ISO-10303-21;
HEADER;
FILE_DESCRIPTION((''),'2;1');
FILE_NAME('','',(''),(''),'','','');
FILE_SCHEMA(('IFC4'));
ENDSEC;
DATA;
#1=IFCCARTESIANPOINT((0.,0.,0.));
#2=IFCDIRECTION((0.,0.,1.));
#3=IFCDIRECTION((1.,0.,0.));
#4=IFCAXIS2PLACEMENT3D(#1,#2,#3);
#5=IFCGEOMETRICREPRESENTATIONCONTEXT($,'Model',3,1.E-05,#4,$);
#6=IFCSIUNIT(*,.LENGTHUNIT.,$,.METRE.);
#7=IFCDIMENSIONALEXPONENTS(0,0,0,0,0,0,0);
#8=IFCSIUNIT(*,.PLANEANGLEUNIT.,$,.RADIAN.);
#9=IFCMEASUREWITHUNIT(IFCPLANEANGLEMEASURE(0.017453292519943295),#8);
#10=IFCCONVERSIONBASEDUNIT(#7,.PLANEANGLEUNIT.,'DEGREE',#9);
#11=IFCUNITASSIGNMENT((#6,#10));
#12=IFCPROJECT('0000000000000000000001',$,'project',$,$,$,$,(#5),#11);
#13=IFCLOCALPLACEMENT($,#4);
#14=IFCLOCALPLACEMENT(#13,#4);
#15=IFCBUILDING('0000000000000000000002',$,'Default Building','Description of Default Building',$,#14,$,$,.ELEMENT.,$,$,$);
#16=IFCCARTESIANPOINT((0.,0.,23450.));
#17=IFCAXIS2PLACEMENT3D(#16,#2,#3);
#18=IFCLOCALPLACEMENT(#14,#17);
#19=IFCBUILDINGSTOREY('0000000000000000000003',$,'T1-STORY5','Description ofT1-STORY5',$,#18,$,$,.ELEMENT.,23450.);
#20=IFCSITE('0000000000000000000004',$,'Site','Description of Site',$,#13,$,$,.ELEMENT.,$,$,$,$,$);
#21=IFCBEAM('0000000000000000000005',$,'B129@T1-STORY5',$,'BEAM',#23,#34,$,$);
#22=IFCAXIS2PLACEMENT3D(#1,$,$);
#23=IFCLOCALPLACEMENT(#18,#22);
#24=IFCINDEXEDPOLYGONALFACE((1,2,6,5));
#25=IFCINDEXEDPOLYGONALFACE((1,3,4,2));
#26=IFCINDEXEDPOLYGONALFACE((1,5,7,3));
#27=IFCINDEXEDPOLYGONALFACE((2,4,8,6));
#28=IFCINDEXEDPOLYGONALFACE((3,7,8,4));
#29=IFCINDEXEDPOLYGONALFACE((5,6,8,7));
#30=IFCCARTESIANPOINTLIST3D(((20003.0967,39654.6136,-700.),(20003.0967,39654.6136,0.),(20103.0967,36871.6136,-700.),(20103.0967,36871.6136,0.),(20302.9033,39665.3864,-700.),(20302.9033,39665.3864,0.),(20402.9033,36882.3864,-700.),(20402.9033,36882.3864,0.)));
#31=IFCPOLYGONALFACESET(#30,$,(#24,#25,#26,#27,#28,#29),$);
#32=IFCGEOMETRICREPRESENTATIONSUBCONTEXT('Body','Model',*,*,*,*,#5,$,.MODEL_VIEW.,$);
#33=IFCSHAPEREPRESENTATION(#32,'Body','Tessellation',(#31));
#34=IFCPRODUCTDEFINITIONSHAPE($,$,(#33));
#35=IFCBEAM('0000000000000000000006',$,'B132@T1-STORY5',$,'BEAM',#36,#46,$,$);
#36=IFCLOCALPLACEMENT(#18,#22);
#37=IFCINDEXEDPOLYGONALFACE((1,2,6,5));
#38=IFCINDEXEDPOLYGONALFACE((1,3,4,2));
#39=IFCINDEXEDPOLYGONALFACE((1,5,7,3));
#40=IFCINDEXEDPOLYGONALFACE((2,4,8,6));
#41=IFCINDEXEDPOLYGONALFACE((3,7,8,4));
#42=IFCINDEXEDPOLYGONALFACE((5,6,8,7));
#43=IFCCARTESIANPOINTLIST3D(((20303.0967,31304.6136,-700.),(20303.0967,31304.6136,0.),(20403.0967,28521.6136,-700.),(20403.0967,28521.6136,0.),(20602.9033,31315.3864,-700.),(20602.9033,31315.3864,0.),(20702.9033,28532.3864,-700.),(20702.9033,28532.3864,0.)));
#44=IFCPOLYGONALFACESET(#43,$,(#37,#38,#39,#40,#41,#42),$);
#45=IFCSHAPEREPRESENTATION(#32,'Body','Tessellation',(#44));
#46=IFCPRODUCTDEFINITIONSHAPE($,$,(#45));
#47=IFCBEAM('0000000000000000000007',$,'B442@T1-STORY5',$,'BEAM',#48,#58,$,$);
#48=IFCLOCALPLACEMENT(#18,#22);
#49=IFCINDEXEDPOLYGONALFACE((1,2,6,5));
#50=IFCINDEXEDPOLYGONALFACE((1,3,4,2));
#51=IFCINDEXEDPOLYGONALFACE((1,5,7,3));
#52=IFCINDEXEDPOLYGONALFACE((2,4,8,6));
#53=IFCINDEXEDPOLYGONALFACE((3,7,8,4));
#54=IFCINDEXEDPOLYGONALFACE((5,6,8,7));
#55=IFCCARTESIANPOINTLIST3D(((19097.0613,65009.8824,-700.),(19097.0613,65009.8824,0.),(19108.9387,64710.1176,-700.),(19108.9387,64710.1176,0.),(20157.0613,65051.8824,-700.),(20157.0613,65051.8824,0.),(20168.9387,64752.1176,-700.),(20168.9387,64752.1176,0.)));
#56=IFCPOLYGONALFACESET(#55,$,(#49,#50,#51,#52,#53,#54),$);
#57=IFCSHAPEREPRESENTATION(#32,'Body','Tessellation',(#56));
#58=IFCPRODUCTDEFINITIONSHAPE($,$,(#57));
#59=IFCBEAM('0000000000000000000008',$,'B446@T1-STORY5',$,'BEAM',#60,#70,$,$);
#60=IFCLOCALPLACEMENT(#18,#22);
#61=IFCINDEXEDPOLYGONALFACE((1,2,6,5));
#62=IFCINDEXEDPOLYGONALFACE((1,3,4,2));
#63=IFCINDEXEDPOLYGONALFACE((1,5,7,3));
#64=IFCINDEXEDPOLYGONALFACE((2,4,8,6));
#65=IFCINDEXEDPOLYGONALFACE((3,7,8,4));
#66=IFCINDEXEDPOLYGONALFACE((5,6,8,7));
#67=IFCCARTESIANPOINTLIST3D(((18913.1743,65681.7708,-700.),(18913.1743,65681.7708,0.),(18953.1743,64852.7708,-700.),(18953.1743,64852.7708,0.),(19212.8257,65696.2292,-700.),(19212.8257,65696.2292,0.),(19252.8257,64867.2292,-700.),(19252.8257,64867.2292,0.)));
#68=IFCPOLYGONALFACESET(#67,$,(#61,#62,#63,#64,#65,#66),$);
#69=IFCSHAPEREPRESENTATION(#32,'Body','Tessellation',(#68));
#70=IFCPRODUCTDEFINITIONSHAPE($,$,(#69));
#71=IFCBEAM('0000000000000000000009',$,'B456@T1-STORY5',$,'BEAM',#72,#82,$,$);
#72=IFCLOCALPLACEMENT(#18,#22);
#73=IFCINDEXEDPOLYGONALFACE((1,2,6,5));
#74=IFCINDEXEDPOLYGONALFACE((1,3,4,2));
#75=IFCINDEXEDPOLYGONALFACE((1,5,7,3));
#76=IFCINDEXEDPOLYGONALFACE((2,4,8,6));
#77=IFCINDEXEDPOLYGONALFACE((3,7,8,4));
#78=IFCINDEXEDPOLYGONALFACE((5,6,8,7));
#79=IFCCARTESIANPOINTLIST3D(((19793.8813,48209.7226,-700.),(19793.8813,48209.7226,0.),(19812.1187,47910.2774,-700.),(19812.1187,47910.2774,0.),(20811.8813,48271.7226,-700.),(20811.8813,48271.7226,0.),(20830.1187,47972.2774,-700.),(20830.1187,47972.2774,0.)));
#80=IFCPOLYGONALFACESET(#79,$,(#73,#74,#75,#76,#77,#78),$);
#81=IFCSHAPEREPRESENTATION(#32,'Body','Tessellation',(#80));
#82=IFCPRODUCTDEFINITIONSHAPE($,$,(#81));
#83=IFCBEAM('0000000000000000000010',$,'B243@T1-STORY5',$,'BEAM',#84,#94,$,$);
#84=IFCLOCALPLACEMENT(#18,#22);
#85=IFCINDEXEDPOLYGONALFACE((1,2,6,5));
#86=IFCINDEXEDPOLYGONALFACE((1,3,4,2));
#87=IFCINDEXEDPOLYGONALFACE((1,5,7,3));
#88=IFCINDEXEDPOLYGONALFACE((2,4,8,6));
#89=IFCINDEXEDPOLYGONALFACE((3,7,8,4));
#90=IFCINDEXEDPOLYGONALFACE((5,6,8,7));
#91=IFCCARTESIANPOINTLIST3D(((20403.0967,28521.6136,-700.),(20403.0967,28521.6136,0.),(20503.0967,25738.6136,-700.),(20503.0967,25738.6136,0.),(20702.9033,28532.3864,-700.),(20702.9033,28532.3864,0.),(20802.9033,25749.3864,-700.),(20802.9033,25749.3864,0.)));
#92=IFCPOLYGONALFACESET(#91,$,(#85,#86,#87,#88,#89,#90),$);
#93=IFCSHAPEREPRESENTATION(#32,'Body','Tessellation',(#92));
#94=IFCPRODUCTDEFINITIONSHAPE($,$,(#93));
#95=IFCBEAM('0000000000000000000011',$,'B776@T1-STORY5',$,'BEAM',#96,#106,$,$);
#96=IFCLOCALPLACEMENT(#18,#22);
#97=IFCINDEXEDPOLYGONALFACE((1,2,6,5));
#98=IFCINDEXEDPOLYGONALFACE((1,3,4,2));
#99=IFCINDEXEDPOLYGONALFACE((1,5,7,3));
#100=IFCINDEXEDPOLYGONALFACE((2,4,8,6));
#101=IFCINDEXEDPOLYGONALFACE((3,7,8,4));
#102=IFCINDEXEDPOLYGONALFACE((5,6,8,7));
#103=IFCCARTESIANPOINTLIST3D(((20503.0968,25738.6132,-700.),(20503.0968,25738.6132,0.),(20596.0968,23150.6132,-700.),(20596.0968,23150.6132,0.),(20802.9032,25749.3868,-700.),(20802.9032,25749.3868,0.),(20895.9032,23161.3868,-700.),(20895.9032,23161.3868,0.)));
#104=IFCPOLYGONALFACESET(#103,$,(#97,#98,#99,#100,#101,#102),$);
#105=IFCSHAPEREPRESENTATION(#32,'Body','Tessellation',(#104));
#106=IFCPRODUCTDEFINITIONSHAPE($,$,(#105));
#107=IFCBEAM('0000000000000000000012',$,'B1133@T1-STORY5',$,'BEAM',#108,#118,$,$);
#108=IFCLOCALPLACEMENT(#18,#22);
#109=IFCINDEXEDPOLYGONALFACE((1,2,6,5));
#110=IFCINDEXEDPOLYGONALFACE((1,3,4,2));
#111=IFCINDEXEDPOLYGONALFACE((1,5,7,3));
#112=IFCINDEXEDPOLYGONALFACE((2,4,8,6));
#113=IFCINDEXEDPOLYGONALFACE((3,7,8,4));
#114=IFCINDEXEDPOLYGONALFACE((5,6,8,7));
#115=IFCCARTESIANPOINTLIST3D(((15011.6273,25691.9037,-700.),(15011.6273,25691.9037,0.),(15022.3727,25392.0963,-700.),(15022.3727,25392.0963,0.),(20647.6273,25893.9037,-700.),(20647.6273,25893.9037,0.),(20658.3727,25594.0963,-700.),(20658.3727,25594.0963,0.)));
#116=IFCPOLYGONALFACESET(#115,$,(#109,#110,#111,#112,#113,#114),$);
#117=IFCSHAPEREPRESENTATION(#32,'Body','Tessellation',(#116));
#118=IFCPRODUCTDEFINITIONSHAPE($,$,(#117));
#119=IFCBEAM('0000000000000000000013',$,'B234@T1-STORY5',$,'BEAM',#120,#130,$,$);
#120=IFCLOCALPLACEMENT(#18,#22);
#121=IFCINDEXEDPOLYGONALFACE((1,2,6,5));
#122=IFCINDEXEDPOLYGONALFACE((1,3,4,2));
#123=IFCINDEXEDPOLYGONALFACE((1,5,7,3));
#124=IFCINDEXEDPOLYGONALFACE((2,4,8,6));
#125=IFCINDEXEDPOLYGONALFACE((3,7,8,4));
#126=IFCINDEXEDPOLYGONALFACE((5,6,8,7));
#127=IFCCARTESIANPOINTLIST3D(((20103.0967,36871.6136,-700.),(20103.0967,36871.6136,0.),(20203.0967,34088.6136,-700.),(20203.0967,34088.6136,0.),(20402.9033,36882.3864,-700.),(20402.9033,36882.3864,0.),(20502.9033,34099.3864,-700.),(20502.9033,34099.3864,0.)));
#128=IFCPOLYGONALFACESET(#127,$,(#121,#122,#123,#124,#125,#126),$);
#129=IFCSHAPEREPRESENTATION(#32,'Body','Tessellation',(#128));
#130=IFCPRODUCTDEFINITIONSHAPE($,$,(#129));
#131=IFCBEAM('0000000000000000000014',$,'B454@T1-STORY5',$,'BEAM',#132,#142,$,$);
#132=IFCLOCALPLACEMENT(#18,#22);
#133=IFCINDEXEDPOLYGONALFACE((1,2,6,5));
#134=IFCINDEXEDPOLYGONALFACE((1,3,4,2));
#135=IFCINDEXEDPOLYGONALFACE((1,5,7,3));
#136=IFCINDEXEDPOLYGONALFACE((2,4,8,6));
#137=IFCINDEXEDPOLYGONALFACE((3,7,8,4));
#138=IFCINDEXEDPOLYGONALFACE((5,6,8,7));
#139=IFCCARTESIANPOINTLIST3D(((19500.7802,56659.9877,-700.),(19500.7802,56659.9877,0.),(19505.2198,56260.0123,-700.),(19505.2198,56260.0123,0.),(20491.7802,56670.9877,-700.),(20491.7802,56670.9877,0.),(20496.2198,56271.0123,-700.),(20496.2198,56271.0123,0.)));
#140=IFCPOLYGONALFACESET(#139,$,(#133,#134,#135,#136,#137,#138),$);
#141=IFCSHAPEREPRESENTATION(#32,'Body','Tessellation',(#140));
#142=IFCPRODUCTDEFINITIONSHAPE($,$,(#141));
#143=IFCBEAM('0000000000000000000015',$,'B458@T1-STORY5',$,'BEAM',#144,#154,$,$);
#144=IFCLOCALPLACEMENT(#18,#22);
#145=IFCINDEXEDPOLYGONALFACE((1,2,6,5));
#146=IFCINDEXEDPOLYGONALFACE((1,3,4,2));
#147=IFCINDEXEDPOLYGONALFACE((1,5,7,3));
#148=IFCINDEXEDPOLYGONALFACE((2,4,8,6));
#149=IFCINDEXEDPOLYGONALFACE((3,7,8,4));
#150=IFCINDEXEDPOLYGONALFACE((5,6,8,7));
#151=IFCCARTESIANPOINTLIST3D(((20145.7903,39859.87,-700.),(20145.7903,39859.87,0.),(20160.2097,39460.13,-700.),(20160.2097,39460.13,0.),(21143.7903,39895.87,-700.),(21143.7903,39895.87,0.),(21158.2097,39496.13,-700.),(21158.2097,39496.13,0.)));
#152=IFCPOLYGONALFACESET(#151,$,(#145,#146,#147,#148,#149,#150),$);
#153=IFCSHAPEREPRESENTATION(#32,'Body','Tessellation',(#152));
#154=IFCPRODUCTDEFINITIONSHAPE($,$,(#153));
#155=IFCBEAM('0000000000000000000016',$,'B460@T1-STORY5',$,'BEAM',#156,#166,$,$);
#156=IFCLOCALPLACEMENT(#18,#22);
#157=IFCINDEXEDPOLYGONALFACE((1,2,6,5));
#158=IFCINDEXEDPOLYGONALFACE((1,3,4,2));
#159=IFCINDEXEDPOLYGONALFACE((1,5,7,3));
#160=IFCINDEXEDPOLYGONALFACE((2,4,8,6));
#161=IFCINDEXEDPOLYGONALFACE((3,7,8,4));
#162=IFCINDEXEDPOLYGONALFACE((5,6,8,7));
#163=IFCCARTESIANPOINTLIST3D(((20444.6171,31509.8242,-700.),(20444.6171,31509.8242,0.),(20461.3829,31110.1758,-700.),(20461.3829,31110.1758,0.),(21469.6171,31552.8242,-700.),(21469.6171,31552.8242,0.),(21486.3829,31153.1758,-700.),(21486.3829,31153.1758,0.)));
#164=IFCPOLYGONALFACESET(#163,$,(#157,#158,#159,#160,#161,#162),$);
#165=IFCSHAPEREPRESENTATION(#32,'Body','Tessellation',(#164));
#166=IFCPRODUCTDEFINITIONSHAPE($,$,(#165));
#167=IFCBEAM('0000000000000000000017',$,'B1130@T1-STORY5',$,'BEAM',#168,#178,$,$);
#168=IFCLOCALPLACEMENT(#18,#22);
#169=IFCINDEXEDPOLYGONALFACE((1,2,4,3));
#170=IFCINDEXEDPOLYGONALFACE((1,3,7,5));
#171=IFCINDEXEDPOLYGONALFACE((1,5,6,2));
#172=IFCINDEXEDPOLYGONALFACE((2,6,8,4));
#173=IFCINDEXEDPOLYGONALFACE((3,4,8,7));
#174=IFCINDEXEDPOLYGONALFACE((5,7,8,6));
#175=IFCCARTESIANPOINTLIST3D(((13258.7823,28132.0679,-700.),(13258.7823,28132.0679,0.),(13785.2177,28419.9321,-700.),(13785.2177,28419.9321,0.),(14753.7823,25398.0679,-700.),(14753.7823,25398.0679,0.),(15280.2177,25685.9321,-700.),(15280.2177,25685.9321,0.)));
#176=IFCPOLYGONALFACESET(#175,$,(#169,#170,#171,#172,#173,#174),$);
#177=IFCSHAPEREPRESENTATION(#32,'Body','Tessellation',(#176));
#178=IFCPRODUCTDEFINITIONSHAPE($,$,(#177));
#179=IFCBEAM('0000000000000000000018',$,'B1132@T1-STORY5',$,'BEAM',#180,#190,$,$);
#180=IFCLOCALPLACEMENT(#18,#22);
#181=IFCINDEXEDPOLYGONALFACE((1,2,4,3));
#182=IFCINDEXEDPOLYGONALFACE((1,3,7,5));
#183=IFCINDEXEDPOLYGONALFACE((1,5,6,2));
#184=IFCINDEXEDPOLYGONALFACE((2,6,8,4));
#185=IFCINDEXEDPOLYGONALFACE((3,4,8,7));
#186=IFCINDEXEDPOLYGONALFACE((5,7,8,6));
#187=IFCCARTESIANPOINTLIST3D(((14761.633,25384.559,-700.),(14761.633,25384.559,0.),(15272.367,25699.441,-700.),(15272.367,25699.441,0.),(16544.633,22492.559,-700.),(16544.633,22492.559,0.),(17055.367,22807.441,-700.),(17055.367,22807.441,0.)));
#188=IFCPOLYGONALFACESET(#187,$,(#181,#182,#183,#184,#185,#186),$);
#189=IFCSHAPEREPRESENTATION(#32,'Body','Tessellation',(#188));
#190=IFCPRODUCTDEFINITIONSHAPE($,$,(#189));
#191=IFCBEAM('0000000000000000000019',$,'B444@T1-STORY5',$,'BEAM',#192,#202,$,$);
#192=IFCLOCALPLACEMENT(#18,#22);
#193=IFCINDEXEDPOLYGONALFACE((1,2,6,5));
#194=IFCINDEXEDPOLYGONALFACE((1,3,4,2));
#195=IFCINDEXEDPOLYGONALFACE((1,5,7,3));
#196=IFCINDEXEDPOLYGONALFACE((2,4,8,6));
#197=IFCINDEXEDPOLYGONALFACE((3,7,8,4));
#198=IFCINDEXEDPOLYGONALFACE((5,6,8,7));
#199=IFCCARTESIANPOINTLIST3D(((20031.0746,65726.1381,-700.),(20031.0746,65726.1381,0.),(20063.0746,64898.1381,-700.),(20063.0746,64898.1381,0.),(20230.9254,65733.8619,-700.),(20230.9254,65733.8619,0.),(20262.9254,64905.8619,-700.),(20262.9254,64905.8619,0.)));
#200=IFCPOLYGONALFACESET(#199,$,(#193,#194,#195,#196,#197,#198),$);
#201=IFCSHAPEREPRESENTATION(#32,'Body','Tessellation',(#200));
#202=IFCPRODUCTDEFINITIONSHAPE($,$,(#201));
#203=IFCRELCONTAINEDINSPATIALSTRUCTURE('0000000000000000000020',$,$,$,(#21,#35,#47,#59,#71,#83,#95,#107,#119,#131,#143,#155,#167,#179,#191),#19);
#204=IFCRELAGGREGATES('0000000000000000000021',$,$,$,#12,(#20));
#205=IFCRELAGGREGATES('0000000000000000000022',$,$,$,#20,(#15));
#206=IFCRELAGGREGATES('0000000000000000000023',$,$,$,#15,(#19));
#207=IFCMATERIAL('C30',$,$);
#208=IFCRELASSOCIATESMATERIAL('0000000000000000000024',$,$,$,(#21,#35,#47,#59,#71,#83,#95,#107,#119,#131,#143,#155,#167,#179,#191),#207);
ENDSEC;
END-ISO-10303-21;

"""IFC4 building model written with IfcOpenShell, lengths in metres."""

from ifc_helpers import new_model, entity, si_unit, converted_unit, frame, origin_with_axes, place, context, subcontext, project, spatial, rectangle, extrude, material, element, save


model = new_model("IFC4")

# Units and contexts
model_context = context("Model", 3, precision=1e-05, world=origin_with_axes())
body_context = subcontext(model_context, "Body", "Model", "MODEL_VIEW")
ifc_project = project(units=[si_unit("LENGTHUNIT", "METRE"), converted_unit("PLANEANGLEUNIT", "DEGREE", entity("IfcPlaneAngleMeasure", 0.017453292519943295), si_unit("PLANEANGLEUNIT", "RADIAN"), dimensions=[0, 0, 0, 0, 0, 0, 0])], contexts=[model_context])

# Site, building, storey
site_placement = place(None, origin_with_axes())
site = spatial("IfcSite", under=ifc_project, at=site_placement, Name="Site", Description="Description of Site", CompositionType="ELEMENT")
building_placement = place(site_placement, origin_with_axes())
building = spatial("IfcBuilding", under=site, at=building_placement, Name="Default Building", Description="Description of Default Building", CompositionType="ELEMENT")
storey_placement = place(building_placement, frame((0.0, 0.0, 23450.0), z_axis=(0.0, 0.0, 1.0), x_axis=(1.0, 0.0, 0.0)))
storey = spatial("IfcBuildingStorey", under=building, at=storey_placement, Name="T1-STORY5", Description="Description ofT1-STORY5", CompositionType="ELEMENT", Elevation=23450.0)

# Beams
ifc_material_1 = material(Name="C30")
for number, where, z_axis, x_axis, name in (
    (1, (20153.0, 39660.0, -350.0), (0.035909, -0.999355, 0.0), (0.999355, 0.035909, 0.0), "B129@T1-STORY5"),
    (2, (20453.0, 31310.0, -350.0), (0.035909, -0.999355, 0.0), (0.999355, 0.035909, 0.0), "B132@T1-STORY5"),
):
    element("IfcBeam", number, at=place(storey_placement, frame(where, z_axis=z_axis, x_axis=x_axis)), inside=storey, material=ifc_material_1, Name=name, ObjectType="BEAM", context=body_context, shape_type="SweptSolid", body=[
        extrude(rectangle(XDim=300.0, YDim=700.0), origin_with_axes(), (0.0, 0.0, 1.0), 2784.796),
    ])
beam_1_placement = place(storey_placement, frame((19103.0, 64860.0, -350.0), z_axis=(0.999216, 0.039592, 0.0), x_axis=(-0.039592, 0.999216, 0.0)))
element("IfcBeam", 3, at=beam_1_placement, inside=storey, material=ifc_material_1, Name="B442@T1-STORY5", ObjectType="BEAM", context=body_context, shape_type="SweptSolid", body=[
    extrude(rectangle(XDim=300.0, YDim=700.0), origin_with_axes(), (0.0, 0.0, 1.0), 1060.8317),
])
beam_2_placement = place(storey_placement, frame((19063.0, 65689.0, -350.0), z_axis=(0.048195, -0.998838, 0.0), x_axis=(0.998838, 0.048195, 0.0)))
element("IfcBeam", 4, at=beam_2_placement, inside=storey, material=ifc_material_1, Name="B446@T1-STORY5", ObjectType="BEAM", context=body_context, shape_type="SweptSolid", body=[
    extrude(rectangle(XDim=300.0, YDim=700.0), origin_with_axes(), (0.0, 0.0, 1.0), 829.9645),
])
beam_3_placement = place(storey_placement, frame((19803.0, 48060.0, -350.0), z_axis=(0.998151, 0.060791, 0.0), x_axis=(-0.060791, 0.998151, 0.0)))
element("IfcBeam", 5, at=beam_3_placement, inside=storey, material=ifc_material_1, Name="B456@T1-STORY5", ObjectType="BEAM", context=body_context, shape_type="SweptSolid", body=[
    extrude(rectangle(XDim=300.0, YDim=700.0), origin_with_axes(), (0.0, 0.0, 1.0), 1019.8863),
])
beam_4_placement = place(storey_placement, frame((20553.0, 28527.0, -350.0), z_axis=(0.035909, -0.999355, 0.0), x_axis=(0.999355, 0.035909, 0.0)))
element("IfcBeam", 6, at=beam_4_placement, inside=storey, material=ifc_material_1, Name="B243@T1-STORY5", ObjectType="BEAM", context=body_context, shape_type="SweptSolid", body=[
    extrude(rectangle(XDim=300.0, YDim=700.0), origin_with_axes(), (0.0, 0.0, 1.0), 2784.796),
])
beam_5_placement = place(storey_placement, frame((20653.0, 25744.0, -350.0), z_axis=(0.035912, -0.999355, 0.0), x_axis=(0.999355, 0.035912, 0.0)))
element("IfcBeam", 7, at=beam_5_placement, inside=storey, material=ifc_material_1, Name="B776@T1-STORY5", ObjectType="BEAM", context=body_context, shape_type="SweptSolid", body=[
    extrude(rectangle(XDim=300.0, YDim=700.0), origin_with_axes(), (0.0, 0.0, 1.0), 2589.6704),
])
beam_6_placement = place(storey_placement, frame((15017.0, 25542.0, -350.0), z_axis=(0.999358, 0.035818, 0.0), x_axis=(-0.035818, 0.999358, 0.0)))
element("IfcBeam", 8, at=beam_6_placement, inside=storey, material=ifc_material_1, Name="B1133@T1-STORY5", ObjectType="BEAM", context=body_context, shape_type="SweptSolid", body=[
    extrude(rectangle(XDim=300.0, YDim=700.0), origin_with_axes(), (0.0, 0.0, 1.0), 5639.6188),
])
beam_7_placement = place(storey_placement, frame((20253.0, 36877.0, -350.0), z_axis=(0.035909, -0.999355, 0.0), x_axis=(0.999355, 0.035909, 0.0)))
element("IfcBeam", 9, at=beam_7_placement, inside=storey, material=ifc_material_1, Name="B234@T1-STORY5", ObjectType="BEAM", context=body_context, shape_type="SweptSolid", body=[
    extrude(rectangle(XDim=300.0, YDim=700.0), origin_with_axes(), (0.0, 0.0, 1.0), 2784.796),
])
beam_8_placement = place(storey_placement, frame((19503.0, 56460.0, -350.0), z_axis=(0.999938, 0.011099, 0.0), x_axis=(-0.011099, 0.999938, 0.0)))
element("IfcBeam", 10, at=beam_8_placement, inside=storey, material=ifc_material_1, Name="B454@T1-STORY5", ObjectType="BEAM", context=body_context, shape_type="SweptSolid", body=[
    extrude(rectangle(XDim=400.0, YDim=700.0), origin_with_axes(), (0.0, 0.0, 1.0), 991.061),
])
beam_9_placement = place(storey_placement, frame((20153.0, 39660.0, -350.0), z_axis=(0.99935, 0.036049, 0.0), x_axis=(-0.036049, 0.99935, 0.0)))
element("IfcBeam", 11, at=beam_9_placement, inside=storey, material=ifc_material_1, Name="B458@T1-STORY5", ObjectType="BEAM", context=body_context, shape_type="SweptSolid", body=[
    extrude(rectangle(XDim=400.0, YDim=700.0), origin_with_axes(), (0.0, 0.0, 1.0), 998.6491),
])
beam_10_placement = place(storey_placement, frame((20453.0, 31310.0, -350.0), z_axis=(0.999121, 0.041914, 0.0), x_axis=(-0.041914, 0.999121, 0.0)))
element("IfcBeam", 12, at=beam_10_placement, inside=storey, material=ifc_material_1, Name="B460@T1-STORY5", ObjectType="BEAM", context=body_context, shape_type="SweptSolid", body=[
    extrude(rectangle(XDim=400.0, YDim=700.0), origin_with_axes(), (0.0, 0.0, 1.0), 1025.9016),
])
beam_11_placement = place(storey_placement, frame((13522.0, 28276.0, -350.0), z_axis=(0.479774, -0.877392, 0.0), x_axis=(0.877392, 0.479774, 0.0)))
element("IfcBeam", 13, at=beam_11_placement, inside=storey, material=ifc_material_1, Name="B1130@T1-STORY5", ObjectType="BEAM", context=body_context, shape_type="SweptSolid", body=[
    extrude(rectangle(XDim=600.0, YDim=700.0), origin_with_axes(), (0.0, 0.0, 1.0), 3116.0521),
])
beam_12_placement = place(storey_placement, frame((15017.0, 25542.0, -350.0), z_axis=(0.524803, -0.851223, 0.0), x_axis=(0.851223, 0.524803, 0.0)))
element("IfcBeam", 14, at=beam_12_placement, inside=storey, material=ifc_material_1, Name="B1132@T1-STORY5", ObjectType="BEAM", context=body_context, shape_type="SweptSolid", body=[
    extrude(rectangle(XDim=600.0, YDim=700.0), origin_with_axes(), (0.0, 0.0, 1.0), 3397.4627),
])
beam_13_placement = place(storey_placement, frame((20131.0, 65730.0, -350.0), z_axis=(0.038619, -0.999254, 0.0), x_axis=(0.999254, 0.038619, 0.0)))
element("IfcBeam", 15, at=beam_13_placement, inside=storey, material=ifc_material_1, Name="B444@T1-STORY5", ObjectType="BEAM", context=body_context, shape_type="SweptSolid", body=[
    extrude(rectangle(XDim=200.0, YDim=700.0), origin_with_axes(), (0.0, 0.0, 1.0), 828.6181),
])

save(model, "model.ifc")
